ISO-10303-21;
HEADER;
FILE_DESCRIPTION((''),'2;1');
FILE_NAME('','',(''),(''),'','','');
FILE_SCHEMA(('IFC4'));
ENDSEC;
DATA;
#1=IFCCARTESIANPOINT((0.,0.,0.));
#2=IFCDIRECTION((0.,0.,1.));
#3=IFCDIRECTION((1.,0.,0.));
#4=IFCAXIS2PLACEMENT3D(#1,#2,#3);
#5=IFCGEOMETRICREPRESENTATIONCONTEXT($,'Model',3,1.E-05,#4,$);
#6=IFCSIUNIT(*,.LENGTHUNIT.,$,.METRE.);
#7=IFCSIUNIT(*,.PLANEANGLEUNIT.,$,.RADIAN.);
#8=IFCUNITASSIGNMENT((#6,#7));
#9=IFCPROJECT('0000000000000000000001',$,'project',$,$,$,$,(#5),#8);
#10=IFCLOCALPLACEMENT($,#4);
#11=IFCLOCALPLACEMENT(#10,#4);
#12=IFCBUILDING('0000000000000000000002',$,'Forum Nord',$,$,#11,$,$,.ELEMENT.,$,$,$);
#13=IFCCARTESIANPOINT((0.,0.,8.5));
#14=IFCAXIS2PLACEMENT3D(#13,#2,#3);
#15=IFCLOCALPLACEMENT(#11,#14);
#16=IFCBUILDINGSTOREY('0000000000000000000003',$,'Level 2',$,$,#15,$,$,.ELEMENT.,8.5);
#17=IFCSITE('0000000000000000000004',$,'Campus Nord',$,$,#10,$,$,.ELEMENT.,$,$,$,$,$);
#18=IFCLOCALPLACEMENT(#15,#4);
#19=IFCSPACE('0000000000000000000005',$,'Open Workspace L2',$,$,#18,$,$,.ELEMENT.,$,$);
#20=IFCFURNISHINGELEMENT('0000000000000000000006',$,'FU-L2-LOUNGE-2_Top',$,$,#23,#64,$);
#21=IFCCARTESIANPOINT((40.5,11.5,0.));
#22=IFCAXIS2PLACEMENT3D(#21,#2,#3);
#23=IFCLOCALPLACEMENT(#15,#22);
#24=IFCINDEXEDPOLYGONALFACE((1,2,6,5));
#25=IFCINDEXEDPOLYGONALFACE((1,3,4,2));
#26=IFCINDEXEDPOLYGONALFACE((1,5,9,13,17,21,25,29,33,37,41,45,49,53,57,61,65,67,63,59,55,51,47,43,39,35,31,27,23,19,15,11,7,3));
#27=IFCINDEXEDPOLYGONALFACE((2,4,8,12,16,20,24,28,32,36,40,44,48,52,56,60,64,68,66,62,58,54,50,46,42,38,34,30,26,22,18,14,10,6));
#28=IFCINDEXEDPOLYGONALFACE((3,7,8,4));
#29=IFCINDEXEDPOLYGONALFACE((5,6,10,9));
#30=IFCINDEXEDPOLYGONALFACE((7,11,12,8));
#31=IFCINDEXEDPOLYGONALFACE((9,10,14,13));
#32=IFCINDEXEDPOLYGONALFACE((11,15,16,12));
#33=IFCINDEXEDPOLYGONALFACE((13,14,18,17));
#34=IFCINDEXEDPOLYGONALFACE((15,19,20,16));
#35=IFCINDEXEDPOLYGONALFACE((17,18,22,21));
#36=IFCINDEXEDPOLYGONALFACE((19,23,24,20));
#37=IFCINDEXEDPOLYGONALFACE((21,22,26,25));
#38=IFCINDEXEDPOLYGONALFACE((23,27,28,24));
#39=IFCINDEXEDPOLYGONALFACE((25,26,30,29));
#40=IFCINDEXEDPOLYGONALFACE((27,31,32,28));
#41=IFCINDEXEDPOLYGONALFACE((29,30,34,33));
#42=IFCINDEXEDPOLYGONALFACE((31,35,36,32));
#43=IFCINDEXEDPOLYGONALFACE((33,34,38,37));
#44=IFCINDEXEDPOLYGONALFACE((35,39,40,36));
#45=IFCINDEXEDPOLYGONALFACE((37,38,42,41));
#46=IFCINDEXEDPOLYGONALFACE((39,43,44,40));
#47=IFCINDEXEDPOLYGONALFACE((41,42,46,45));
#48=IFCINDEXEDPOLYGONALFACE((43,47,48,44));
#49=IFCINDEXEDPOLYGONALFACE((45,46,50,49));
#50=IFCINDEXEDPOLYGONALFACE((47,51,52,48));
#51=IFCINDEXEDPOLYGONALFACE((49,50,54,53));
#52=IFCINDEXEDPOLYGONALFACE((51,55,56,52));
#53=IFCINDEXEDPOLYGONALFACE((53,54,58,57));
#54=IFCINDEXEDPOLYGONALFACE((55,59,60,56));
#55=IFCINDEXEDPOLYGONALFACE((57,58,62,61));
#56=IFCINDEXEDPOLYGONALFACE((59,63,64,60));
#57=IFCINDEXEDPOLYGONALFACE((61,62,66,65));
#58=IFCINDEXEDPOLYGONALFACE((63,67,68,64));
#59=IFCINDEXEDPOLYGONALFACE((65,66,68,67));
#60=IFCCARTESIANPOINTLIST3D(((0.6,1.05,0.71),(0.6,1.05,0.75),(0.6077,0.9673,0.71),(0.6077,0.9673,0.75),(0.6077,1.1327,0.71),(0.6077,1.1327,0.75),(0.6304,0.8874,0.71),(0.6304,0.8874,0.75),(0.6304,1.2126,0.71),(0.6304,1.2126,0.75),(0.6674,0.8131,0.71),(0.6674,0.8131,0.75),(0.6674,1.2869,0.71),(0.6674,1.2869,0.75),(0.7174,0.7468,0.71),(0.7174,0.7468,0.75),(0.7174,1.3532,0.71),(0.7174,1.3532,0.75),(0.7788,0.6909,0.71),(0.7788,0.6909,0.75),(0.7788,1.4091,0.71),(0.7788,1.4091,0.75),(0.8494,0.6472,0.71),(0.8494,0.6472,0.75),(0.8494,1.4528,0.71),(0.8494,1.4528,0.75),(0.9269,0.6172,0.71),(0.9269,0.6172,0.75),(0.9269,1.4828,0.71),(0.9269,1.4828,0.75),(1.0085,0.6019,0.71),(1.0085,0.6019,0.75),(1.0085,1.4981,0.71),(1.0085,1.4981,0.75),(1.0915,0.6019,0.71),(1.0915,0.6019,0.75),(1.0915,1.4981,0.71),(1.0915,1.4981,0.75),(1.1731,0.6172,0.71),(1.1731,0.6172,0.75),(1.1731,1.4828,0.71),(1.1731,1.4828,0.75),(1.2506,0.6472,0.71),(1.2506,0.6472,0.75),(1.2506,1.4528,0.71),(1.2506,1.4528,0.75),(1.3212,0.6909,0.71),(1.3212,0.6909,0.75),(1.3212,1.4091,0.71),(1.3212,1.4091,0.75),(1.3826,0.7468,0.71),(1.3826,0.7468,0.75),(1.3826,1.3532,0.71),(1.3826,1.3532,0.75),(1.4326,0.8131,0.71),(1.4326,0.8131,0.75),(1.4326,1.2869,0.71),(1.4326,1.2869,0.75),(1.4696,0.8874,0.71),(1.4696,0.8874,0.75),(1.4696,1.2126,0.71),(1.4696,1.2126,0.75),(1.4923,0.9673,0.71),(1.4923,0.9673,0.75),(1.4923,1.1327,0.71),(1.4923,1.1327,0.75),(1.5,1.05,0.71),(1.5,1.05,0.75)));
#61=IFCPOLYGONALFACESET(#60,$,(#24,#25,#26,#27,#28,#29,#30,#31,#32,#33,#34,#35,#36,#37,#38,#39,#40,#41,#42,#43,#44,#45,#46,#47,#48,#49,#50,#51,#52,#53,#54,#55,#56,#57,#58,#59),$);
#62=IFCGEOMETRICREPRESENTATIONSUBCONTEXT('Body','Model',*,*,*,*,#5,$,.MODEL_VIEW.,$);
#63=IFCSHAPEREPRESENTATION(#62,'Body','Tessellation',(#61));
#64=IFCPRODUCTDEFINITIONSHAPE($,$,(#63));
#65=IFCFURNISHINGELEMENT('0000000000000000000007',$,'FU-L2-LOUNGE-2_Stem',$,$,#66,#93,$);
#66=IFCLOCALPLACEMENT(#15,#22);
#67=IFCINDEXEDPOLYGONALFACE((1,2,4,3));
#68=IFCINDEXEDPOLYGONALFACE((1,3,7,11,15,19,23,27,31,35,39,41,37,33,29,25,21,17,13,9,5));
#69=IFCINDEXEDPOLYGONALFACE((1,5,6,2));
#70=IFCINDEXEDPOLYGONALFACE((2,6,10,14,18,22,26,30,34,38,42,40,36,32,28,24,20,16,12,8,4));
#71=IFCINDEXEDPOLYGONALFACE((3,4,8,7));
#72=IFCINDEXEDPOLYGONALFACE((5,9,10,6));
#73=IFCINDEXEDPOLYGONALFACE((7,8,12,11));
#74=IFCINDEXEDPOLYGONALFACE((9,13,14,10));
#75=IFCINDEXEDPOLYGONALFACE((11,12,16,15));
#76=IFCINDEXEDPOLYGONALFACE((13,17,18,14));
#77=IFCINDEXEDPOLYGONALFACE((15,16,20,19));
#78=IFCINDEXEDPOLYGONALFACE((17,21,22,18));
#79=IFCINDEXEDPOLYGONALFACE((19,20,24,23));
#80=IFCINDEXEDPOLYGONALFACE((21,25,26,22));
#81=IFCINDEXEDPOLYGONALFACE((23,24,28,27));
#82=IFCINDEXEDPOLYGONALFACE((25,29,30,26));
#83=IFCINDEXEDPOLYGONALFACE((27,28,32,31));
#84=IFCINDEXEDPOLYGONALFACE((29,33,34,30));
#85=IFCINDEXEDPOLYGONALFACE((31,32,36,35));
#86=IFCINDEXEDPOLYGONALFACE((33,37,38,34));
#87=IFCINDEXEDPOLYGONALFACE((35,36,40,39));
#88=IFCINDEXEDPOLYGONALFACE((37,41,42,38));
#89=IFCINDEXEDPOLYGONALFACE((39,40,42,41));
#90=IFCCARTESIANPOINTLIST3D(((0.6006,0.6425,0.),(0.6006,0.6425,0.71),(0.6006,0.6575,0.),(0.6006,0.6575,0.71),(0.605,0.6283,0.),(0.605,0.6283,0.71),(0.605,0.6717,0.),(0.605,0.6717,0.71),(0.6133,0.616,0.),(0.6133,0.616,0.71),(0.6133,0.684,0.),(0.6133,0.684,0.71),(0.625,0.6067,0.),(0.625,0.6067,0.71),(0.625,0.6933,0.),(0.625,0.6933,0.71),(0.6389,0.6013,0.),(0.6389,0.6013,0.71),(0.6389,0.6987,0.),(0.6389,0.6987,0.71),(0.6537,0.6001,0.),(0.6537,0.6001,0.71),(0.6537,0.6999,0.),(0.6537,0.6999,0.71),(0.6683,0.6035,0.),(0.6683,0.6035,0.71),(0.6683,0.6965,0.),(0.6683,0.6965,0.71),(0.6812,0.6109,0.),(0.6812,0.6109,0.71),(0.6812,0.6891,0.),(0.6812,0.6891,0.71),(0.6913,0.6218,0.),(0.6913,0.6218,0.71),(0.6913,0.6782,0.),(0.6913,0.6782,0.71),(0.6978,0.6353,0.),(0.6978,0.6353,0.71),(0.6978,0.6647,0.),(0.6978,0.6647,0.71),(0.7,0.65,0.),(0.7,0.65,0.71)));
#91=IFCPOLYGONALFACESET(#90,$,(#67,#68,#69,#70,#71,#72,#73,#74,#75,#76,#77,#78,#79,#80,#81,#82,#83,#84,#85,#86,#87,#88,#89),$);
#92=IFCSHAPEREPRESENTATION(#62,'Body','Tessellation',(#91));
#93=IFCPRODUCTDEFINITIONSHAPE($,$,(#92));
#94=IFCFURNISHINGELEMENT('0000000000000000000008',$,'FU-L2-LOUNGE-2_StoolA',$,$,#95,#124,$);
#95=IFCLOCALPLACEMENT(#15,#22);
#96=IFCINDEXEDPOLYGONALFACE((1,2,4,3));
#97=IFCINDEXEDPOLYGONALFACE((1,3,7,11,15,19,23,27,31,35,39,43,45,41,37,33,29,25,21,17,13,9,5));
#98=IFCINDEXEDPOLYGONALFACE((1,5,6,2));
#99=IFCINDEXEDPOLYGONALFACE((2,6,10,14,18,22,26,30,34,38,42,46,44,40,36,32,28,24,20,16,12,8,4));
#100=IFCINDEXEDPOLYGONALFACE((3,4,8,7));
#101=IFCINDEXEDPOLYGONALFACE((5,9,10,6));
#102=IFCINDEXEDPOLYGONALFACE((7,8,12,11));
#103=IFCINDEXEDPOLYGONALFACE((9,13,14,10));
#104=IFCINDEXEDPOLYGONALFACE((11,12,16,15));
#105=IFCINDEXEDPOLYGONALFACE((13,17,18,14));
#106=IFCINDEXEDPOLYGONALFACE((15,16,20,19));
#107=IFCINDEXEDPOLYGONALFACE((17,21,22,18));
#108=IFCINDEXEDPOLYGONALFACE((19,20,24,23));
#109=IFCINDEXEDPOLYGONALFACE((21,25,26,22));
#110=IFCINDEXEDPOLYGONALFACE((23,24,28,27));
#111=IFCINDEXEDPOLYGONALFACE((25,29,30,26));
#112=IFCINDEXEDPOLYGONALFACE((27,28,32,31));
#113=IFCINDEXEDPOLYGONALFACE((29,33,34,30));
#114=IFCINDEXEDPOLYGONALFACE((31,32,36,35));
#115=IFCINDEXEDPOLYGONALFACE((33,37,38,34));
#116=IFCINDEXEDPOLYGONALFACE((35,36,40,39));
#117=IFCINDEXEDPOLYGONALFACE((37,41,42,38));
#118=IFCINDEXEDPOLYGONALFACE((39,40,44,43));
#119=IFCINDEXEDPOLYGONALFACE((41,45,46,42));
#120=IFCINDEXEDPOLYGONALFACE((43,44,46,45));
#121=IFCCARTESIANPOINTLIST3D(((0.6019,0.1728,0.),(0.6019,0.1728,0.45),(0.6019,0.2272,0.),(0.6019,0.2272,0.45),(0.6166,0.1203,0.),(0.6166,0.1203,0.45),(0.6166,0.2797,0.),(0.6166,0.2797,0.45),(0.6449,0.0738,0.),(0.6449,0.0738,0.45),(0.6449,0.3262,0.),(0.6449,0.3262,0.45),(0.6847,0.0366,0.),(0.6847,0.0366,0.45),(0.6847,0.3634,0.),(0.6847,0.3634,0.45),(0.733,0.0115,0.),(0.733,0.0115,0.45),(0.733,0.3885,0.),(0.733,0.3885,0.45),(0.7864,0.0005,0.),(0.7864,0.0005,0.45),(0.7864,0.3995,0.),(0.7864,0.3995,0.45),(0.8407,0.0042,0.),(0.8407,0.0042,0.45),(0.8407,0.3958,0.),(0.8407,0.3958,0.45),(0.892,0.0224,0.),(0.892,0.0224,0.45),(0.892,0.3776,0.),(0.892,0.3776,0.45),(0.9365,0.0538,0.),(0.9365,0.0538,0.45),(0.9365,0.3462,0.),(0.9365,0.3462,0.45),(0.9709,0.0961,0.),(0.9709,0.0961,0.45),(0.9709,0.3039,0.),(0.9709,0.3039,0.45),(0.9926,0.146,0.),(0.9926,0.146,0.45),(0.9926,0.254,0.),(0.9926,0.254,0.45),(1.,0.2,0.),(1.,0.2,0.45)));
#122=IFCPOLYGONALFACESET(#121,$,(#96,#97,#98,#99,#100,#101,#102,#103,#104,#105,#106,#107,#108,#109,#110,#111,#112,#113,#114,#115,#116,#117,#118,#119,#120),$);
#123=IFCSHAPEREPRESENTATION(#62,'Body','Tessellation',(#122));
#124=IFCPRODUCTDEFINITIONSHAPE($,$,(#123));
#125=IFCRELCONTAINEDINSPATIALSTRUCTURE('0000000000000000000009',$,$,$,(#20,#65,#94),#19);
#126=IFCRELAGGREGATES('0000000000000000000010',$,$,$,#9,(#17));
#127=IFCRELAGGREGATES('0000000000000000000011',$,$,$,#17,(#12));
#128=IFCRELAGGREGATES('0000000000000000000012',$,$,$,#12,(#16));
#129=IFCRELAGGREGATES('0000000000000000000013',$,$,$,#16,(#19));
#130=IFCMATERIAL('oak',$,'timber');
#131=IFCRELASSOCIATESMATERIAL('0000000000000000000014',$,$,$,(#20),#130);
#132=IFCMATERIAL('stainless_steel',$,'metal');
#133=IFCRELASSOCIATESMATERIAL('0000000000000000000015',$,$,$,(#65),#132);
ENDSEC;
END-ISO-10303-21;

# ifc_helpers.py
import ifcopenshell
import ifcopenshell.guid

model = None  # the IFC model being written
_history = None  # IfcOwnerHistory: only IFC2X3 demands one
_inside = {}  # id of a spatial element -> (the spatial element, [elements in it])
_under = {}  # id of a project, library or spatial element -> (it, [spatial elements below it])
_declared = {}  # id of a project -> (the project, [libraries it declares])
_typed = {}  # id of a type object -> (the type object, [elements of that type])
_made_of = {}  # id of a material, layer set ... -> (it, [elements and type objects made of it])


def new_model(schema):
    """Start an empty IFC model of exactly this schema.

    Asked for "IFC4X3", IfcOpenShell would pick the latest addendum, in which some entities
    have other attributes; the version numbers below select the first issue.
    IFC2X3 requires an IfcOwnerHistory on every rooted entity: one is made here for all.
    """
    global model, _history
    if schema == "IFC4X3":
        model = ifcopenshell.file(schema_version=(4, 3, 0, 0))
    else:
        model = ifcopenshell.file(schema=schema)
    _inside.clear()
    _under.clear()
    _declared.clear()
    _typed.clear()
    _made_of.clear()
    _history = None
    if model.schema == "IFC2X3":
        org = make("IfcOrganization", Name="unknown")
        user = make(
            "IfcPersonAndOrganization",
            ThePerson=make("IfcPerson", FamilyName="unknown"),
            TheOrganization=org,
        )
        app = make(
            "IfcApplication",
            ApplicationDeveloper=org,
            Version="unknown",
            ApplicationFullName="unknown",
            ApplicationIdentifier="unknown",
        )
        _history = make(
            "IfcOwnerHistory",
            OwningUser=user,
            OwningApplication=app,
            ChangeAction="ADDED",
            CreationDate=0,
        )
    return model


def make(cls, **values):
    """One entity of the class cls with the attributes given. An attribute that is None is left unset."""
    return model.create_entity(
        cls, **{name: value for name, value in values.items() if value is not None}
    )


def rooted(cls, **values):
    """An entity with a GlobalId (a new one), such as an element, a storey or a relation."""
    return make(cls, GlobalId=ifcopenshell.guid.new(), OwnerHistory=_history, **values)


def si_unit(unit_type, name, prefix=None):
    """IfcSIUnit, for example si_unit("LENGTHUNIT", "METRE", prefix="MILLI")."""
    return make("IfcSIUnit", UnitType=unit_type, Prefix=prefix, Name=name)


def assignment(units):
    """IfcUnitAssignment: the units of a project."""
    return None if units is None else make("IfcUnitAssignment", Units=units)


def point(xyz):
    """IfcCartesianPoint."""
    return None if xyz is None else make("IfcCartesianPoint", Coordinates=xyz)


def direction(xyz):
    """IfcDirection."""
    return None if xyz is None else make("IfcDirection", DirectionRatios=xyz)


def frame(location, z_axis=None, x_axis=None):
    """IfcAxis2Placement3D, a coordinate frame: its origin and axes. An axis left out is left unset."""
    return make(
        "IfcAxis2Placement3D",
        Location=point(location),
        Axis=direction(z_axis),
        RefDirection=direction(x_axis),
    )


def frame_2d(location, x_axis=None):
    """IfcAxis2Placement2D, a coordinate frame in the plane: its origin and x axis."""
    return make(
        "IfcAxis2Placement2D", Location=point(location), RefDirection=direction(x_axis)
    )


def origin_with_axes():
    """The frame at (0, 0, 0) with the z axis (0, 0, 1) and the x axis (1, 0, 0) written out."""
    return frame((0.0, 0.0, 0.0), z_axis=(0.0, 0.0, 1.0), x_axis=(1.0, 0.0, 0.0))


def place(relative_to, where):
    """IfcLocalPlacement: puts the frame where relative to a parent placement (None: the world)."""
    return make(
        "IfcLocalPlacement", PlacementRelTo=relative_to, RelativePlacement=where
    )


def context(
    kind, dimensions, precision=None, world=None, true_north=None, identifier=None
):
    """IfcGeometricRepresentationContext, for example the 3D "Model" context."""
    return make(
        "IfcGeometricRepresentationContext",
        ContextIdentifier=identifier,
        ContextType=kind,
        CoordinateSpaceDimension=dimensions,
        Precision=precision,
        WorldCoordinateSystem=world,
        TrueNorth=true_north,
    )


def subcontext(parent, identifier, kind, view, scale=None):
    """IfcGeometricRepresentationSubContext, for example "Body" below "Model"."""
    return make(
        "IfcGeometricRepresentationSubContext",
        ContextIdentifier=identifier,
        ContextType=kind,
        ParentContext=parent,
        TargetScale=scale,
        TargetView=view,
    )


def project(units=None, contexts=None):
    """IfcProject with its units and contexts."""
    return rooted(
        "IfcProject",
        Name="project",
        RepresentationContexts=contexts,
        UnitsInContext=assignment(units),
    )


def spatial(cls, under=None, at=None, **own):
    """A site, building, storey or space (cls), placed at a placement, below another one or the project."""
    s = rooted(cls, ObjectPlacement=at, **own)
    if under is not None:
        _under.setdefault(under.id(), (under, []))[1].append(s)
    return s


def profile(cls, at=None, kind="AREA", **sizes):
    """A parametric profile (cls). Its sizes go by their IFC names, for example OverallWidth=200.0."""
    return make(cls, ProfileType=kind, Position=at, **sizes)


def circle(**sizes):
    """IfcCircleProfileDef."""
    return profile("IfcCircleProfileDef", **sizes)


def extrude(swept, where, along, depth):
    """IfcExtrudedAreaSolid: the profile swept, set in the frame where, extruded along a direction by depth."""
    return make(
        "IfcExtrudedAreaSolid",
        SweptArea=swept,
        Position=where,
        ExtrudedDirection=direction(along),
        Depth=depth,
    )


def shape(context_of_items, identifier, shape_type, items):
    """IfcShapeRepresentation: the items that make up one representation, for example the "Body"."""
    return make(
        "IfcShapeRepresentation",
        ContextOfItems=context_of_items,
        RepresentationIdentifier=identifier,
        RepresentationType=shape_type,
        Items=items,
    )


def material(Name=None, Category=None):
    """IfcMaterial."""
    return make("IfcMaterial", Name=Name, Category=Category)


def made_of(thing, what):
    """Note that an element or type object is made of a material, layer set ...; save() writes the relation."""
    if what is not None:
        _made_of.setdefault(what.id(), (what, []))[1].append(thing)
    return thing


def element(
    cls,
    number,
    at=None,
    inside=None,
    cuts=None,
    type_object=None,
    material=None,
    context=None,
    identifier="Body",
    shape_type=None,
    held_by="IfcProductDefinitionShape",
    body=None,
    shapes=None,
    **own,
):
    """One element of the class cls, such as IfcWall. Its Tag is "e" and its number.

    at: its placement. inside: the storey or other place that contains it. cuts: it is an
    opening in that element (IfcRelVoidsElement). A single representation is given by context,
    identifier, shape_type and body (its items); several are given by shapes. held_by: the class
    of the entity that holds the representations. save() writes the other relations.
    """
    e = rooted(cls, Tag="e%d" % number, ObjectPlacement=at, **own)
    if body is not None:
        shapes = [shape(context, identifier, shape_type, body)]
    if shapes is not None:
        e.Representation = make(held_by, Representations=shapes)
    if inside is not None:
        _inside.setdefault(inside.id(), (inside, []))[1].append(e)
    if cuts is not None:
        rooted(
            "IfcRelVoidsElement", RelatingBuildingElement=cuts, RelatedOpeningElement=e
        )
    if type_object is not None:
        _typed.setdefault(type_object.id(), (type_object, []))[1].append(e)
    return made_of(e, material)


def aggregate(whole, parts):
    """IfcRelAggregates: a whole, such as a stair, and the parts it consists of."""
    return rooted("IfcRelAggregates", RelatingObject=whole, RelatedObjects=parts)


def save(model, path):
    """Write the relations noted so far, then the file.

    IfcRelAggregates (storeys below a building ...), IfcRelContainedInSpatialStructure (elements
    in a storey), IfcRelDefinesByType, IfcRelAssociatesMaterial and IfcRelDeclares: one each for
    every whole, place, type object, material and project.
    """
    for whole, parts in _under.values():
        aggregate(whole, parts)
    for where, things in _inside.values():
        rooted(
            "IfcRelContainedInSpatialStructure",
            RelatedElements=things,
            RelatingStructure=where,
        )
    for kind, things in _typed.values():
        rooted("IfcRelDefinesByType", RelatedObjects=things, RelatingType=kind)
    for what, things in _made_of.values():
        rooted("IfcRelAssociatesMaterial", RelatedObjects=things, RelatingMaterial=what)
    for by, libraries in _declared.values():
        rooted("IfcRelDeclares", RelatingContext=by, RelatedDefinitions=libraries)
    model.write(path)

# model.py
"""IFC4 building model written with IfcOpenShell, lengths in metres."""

from ifc_helpers import new_model, si_unit, frame, frame_2d, origin_with_axes, place, context, subcontext, project, spatial, circle, extrude, material, element, save


model = new_model("IFC4")

# Units and contexts
model_context = context("Model", 3, precision=1e-05, world=origin_with_axes())
body_context = subcontext(model_context, "Body", "Model", "MODEL_VIEW")
ifc_project = project(units=[si_unit("LENGTHUNIT", "METRE"), si_unit("PLANEANGLEUNIT", "RADIAN")], contexts=[model_context])

# Site, building, storey
site_placement = place(None, origin_with_axes())
site = spatial("IfcSite", under=ifc_project, at=site_placement, Name="Campus Nord", CompositionType="ELEMENT")
building_placement = place(site_placement, origin_with_axes())
building = spatial("IfcBuilding", under=site, at=building_placement, Name="Forum Nord", CompositionType="ELEMENT")
storey_placement = place(building_placement, frame((0.0, 0.0, 8.5), z_axis=(0.0, 0.0, 1.0), x_axis=(1.0, 0.0, 0.0)))
storey = spatial("IfcBuildingStorey", under=building, at=storey_placement, Name="Level 2", CompositionType="ELEMENT", Elevation=8.5)

# Shared definitions
ifc_material_1 = material(Name="stainless_steel", Category="metal")

# Shared definitions
space_placement = place(storey_placement, origin_with_axes())
space = spatial("IfcSpace", under=storey, at=space_placement, Name="Open Workspace L2", CompositionType="ELEMENT")

# Furnishing elements
ifc_material_2 = material(Name="oak", Category="timber")
furnishing_1_placement = place(storey_placement, frame((40.5, 11.5, 0.0), z_axis=(0.0, 0.0, 1.0), x_axis=(1.0, 0.0, 0.0)))
element("IfcFurnishingElement", 1, at=furnishing_1_placement, inside=space, material=ifc_material_2, Name="FU-L2-LOUNGE-2_Top", context=body_context, shape_type="SweptSolid", body=[
    extrude(circle(Radius=0.45, at=frame_2d((1.05, 1.05), x_axis=(1.0, 0.0))), frame((0.0, 0.0, 0.71), z_axis=(0.0, 0.0, 1.0), x_axis=(1.0, 0.0, 0.0)), (0.0, 0.0, 1.0), 0.04),
])
furnishing_2_placement = place(storey_placement, frame((40.5, 11.5, 0.0), z_axis=(0.0, 0.0, 1.0), x_axis=(1.0, 0.0, 0.0)))
element("IfcFurnishingElement", 2, at=furnishing_2_placement, inside=space, material=ifc_material_1, Name="FU-L2-LOUNGE-2_Stem", context=body_context, shape_type="SweptSolid", body=[
    extrude(circle(Radius=0.05, at=frame_2d((0.65, 0.65), x_axis=(1.0, 0.0))), origin_with_axes(), (0.0, 0.0, 1.0), 0.71),
])
furnishing_3_placement = place(storey_placement, frame((40.5, 11.5, 0.0), z_axis=(0.0, 0.0, 1.0), x_axis=(1.0, 0.0, 0.0)))
element("IfcFurnishingElement", 3, at=furnishing_3_placement, inside=space, Name="FU-L2-LOUNGE-2_StoolA", context=body_context, shape_type="SweptSolid", body=[
    extrude(circle(Radius=0.2, at=frame_2d((0.8, 0.2), x_axis=(1.0, 0.0))), origin_with_axes(), (0.0, 0.0, 1.0), 0.45),
])

save(model, "model.ifc")
